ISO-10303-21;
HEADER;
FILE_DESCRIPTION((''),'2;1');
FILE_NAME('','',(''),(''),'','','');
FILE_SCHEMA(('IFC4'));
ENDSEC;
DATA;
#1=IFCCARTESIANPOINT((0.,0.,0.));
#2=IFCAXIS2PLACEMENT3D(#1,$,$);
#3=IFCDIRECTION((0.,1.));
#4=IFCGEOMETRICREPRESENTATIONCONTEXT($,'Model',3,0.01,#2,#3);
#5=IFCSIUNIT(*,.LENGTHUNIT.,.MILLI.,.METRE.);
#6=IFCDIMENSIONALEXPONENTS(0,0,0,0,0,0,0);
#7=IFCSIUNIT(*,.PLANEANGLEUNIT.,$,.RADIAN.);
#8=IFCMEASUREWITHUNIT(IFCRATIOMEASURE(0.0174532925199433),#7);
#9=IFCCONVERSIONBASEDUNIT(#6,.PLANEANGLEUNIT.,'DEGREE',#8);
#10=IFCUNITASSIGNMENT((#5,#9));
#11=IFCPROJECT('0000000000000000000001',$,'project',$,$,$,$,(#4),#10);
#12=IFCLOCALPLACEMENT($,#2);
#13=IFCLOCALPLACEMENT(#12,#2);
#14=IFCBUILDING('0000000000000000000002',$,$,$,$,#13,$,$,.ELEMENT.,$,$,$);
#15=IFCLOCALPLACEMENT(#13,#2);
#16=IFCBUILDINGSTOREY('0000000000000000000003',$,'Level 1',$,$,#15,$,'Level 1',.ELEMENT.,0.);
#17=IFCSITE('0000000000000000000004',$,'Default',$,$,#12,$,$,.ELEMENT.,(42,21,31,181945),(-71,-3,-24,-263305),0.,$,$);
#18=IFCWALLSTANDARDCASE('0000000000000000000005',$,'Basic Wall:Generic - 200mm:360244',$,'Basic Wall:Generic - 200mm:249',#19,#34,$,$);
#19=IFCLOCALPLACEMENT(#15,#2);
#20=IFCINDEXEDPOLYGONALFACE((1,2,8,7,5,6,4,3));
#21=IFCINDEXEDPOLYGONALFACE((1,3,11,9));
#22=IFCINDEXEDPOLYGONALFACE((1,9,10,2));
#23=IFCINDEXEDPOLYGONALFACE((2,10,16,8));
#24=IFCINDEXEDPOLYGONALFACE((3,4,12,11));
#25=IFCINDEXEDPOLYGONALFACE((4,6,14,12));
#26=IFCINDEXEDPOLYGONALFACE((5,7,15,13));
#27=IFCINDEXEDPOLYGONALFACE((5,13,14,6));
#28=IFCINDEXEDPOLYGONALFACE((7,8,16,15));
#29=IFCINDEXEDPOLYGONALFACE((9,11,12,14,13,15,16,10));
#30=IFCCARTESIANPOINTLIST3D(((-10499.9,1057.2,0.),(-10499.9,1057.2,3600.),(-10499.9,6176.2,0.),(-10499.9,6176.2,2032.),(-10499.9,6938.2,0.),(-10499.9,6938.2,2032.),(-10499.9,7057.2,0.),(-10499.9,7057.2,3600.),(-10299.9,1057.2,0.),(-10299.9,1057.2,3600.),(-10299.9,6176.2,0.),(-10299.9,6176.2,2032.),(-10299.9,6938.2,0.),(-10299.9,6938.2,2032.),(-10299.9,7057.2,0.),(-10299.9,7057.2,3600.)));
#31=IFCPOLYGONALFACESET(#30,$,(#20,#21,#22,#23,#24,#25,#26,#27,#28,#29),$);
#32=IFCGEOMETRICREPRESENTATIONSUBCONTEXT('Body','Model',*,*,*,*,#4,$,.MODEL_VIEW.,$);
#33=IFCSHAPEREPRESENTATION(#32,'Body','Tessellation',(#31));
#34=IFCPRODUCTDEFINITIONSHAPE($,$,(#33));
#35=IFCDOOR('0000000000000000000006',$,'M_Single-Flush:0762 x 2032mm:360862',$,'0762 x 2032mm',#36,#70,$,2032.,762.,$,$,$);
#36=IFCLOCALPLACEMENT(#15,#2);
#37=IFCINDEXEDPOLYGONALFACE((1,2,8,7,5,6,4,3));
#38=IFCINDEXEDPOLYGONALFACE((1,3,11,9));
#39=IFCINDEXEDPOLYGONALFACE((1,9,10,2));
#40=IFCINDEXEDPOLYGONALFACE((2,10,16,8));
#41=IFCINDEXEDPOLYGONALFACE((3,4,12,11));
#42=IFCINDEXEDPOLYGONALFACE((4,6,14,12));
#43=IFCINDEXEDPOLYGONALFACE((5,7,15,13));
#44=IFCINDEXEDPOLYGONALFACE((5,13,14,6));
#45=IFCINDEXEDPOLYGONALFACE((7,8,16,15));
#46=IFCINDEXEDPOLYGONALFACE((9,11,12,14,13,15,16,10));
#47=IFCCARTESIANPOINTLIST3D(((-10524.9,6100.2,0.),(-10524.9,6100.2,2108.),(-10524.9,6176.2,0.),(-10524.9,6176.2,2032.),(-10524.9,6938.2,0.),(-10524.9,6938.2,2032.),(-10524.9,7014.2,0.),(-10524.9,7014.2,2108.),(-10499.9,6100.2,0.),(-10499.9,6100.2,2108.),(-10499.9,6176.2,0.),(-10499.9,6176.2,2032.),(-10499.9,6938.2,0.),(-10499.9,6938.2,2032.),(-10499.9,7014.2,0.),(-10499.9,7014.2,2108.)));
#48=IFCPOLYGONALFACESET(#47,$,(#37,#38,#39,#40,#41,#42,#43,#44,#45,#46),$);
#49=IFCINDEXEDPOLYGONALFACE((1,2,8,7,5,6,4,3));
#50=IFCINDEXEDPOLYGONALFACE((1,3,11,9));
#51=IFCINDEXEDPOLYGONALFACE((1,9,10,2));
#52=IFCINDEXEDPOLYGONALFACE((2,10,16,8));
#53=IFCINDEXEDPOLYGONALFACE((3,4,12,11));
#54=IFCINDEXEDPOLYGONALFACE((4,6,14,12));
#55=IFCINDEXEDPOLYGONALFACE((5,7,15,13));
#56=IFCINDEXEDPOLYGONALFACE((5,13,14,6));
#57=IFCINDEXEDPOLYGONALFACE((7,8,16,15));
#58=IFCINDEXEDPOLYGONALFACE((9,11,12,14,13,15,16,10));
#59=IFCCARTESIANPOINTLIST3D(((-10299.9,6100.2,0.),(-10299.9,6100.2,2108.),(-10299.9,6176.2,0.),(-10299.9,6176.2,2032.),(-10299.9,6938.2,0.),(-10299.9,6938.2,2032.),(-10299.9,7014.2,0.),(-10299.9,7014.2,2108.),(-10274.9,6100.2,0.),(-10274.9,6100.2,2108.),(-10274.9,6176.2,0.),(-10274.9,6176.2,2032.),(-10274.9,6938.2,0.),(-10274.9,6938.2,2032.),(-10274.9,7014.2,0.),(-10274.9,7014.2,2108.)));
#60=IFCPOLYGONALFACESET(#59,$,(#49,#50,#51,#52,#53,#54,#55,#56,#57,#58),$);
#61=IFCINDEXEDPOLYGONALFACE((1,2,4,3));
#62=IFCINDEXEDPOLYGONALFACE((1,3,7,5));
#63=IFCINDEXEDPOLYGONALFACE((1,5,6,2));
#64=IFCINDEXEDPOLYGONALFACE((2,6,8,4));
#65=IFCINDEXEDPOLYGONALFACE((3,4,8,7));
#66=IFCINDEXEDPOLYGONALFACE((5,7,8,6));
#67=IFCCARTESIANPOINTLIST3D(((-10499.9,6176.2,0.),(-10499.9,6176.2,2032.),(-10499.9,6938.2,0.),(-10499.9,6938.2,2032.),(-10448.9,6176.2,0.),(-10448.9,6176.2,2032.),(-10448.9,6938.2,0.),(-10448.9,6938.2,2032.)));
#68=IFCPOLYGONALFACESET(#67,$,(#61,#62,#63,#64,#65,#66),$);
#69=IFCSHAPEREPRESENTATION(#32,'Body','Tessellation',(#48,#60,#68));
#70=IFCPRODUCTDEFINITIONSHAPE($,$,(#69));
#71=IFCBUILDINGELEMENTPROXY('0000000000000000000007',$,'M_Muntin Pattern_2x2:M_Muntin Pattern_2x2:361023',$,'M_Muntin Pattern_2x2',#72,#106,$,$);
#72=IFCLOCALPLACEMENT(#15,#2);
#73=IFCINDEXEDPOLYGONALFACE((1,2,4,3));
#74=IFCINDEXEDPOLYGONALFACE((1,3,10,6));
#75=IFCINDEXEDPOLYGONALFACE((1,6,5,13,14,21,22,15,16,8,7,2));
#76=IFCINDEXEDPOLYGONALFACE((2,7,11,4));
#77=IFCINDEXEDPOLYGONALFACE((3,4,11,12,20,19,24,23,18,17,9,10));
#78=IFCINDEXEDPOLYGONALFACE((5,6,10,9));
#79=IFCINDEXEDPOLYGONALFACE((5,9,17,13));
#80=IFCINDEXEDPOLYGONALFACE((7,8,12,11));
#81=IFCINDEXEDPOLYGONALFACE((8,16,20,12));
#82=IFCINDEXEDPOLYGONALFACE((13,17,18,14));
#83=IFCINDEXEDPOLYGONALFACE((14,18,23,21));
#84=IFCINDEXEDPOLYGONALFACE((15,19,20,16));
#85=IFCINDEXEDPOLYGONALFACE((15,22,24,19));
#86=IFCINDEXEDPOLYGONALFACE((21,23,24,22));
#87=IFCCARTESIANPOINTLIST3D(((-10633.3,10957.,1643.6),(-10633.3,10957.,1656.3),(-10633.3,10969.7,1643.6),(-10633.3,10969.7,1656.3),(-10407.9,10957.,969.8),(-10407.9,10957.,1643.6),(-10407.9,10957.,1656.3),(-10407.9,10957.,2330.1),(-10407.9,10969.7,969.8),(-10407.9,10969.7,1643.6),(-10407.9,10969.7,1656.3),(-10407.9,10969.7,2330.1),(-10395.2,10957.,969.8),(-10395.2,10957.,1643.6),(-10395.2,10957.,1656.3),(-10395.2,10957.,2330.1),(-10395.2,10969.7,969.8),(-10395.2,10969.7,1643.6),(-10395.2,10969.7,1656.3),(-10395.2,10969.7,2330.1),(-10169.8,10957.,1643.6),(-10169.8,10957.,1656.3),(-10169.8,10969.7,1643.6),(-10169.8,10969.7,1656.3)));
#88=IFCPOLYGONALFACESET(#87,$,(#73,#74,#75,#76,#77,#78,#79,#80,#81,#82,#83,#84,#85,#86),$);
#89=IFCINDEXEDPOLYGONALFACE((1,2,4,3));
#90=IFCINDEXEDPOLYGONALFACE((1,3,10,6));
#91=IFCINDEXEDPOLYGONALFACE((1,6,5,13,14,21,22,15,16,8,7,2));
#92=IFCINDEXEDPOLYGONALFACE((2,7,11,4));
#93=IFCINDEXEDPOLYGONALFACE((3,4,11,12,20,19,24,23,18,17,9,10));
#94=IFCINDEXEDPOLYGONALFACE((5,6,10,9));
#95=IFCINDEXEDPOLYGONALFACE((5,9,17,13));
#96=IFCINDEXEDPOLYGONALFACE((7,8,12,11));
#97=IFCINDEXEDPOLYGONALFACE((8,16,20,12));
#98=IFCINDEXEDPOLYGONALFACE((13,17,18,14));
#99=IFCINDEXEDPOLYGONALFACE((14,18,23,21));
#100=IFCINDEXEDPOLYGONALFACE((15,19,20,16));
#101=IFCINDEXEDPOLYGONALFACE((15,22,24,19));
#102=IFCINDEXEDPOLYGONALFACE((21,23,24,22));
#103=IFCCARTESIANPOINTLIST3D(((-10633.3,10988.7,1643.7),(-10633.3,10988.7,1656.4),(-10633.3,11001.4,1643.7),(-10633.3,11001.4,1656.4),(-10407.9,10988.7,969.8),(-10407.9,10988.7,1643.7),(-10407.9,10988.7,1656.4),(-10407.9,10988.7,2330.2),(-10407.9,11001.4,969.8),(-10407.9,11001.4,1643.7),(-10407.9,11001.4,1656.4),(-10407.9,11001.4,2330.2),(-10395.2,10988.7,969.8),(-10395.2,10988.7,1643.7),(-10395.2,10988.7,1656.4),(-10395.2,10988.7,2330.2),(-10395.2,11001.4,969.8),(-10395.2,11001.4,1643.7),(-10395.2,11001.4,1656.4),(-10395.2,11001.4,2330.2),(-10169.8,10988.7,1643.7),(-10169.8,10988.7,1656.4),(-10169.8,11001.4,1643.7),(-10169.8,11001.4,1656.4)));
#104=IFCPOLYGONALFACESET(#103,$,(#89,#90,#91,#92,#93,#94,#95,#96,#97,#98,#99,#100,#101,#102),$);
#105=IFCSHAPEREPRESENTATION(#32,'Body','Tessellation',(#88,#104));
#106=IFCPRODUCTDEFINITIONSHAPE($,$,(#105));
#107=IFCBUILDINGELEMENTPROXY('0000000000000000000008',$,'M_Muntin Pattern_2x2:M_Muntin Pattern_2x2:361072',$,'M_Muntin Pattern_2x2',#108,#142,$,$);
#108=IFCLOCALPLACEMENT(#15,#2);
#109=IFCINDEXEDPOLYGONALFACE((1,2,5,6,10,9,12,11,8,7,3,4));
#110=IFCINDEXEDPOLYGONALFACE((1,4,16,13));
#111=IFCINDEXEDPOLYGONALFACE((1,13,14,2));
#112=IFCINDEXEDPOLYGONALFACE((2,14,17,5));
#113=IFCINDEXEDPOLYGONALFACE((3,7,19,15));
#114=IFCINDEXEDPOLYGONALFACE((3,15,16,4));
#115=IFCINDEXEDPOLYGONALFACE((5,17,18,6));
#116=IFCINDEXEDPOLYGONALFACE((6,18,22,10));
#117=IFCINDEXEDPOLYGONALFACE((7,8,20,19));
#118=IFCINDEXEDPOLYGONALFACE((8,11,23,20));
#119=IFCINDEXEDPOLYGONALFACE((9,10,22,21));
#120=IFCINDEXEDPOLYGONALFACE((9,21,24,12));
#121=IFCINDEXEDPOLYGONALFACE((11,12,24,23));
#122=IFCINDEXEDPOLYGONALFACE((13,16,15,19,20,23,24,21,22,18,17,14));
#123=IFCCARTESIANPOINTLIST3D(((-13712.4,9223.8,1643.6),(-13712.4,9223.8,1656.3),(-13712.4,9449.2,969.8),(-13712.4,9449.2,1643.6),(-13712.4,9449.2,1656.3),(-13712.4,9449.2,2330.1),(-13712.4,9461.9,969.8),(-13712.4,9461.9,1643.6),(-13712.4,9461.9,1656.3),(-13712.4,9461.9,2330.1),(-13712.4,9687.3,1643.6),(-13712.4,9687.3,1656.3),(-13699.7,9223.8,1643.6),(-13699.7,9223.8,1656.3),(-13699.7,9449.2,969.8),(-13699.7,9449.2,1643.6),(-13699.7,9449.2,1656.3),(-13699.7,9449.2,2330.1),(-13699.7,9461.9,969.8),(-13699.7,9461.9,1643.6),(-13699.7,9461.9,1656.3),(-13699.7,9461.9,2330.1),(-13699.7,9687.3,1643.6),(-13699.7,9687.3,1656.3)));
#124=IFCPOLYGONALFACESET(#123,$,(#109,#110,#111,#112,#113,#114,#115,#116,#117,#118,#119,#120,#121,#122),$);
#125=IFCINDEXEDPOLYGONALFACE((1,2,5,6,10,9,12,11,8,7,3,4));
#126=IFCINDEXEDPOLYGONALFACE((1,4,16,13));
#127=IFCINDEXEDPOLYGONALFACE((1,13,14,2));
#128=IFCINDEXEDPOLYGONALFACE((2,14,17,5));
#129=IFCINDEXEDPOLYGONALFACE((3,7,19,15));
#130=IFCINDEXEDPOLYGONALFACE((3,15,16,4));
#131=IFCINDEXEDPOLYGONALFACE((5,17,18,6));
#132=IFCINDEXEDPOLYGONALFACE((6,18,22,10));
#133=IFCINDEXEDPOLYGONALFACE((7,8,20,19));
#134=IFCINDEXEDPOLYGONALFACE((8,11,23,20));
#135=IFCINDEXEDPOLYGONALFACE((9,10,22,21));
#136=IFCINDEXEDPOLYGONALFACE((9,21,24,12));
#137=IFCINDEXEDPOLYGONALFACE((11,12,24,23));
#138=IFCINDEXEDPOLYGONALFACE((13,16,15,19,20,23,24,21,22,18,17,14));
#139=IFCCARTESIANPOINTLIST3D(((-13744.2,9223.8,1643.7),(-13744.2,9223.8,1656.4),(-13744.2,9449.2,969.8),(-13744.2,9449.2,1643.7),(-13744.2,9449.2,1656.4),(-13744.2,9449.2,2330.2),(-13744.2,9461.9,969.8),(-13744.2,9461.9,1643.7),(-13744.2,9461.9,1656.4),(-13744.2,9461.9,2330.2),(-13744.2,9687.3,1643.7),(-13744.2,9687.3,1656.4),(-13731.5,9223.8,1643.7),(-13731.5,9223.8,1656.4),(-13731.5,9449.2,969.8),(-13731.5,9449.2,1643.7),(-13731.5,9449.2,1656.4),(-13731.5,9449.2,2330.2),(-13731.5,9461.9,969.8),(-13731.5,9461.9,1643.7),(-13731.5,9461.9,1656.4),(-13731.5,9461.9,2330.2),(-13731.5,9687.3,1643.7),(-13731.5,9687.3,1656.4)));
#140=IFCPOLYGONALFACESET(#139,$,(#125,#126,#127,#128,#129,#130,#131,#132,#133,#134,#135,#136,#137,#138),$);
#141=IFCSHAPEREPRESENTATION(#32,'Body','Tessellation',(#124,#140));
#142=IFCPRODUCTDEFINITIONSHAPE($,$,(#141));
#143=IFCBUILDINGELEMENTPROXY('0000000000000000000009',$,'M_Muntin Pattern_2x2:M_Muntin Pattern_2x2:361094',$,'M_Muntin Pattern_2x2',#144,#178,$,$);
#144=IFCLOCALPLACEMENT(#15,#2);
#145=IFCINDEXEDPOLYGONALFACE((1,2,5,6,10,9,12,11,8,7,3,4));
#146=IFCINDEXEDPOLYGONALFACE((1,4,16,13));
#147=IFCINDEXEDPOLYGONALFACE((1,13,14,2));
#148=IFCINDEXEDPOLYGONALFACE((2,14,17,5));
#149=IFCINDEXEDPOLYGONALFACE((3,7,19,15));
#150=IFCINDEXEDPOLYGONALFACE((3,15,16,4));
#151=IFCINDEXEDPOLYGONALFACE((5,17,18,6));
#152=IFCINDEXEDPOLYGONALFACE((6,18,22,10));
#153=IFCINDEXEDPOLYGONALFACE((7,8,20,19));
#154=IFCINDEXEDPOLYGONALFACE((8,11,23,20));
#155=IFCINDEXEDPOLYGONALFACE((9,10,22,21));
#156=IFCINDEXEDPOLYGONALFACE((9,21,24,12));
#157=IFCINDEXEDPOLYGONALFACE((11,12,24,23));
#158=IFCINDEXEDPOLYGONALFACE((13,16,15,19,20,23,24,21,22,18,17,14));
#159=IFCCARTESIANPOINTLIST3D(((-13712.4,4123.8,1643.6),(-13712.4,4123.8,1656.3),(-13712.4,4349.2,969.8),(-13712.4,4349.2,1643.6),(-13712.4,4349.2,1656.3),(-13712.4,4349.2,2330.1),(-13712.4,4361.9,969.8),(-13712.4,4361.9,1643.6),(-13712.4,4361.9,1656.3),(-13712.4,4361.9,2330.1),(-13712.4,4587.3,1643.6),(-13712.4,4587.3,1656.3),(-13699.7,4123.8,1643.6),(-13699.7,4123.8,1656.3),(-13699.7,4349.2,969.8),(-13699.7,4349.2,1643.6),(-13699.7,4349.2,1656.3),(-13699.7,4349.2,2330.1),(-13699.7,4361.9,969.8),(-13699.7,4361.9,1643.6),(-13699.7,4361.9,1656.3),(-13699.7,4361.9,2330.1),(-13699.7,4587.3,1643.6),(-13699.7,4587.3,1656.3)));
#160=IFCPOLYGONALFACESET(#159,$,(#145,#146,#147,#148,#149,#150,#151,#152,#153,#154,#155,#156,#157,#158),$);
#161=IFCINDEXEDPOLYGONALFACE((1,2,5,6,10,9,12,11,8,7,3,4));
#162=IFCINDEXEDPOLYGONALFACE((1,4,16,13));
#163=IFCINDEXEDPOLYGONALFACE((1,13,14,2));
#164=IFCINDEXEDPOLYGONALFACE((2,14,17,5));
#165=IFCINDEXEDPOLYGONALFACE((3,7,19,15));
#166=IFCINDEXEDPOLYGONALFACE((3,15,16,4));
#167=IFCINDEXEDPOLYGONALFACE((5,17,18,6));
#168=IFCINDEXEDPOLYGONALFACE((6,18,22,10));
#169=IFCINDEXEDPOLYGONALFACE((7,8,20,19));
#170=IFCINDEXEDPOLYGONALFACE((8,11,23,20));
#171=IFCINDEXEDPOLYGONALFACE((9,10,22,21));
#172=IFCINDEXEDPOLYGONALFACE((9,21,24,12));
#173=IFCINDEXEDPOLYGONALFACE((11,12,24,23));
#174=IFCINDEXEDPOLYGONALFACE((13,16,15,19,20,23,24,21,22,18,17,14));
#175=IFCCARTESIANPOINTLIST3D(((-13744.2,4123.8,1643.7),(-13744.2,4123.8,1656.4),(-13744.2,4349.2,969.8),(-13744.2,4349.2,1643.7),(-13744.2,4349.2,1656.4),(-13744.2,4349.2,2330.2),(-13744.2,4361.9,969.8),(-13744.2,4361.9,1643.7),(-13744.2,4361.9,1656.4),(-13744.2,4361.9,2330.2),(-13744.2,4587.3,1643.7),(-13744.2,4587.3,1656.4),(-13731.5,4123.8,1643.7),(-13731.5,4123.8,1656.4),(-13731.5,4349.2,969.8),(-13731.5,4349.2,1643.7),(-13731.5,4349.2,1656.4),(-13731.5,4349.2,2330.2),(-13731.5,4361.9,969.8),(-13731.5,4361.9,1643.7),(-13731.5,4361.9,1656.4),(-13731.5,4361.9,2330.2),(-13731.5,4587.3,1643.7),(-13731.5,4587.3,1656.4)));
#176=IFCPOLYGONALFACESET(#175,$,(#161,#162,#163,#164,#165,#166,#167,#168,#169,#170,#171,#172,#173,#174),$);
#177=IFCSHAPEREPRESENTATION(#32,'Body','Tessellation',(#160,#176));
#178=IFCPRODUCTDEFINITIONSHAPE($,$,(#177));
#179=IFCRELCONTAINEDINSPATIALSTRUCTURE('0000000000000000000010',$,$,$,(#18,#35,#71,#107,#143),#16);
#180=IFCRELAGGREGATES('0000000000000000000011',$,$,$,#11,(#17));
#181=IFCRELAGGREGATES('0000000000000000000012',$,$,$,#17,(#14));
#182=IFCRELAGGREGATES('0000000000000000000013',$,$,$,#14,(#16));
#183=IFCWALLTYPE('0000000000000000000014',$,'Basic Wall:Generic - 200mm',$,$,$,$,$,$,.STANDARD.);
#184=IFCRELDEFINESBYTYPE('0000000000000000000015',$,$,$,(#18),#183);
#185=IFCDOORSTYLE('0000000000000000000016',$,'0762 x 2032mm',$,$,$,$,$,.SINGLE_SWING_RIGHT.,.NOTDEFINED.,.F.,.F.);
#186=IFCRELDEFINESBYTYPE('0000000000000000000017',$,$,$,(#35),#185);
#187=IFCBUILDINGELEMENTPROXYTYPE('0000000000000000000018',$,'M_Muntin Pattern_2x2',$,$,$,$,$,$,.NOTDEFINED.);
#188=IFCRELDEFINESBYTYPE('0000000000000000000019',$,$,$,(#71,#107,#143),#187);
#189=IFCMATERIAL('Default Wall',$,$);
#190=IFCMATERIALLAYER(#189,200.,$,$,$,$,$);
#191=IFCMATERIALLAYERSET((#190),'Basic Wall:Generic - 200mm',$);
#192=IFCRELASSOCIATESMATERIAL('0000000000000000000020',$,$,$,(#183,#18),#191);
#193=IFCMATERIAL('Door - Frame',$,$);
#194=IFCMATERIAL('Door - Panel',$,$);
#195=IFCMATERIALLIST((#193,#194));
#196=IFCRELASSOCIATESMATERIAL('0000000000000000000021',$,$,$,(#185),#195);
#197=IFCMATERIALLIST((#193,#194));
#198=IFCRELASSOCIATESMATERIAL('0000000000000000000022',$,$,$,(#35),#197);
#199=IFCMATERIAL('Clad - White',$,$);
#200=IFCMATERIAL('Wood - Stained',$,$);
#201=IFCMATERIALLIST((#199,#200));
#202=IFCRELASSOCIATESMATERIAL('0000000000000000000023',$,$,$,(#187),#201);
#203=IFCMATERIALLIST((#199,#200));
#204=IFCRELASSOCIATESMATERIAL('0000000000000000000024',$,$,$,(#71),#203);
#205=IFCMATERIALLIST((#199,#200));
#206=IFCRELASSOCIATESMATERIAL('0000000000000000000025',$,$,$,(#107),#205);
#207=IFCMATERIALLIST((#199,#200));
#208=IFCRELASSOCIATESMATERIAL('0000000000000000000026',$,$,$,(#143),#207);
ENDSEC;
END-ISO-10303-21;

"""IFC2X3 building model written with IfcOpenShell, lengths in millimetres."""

from ifc_helpers import new_model, entity, si_unit, converted_unit, direction, frame, frame_2d, origin, place, context, subcontext, project, spatial, polyline, rectangle, outline, extrude, clip, bounded_halfspace, source, transform, mapped, material, material_list, layer, layer_set, layer_usage, type_object, type_shapes, element, fill, save


model = new_model("IFC2X3")

# Units and contexts
model_context = context("Model", 3, precision=0.01, world=origin(), true_north=direction((0.0, 1.0)))
body_context = subcontext(model_context, "Body", "Model", "MODEL_VIEW")
ifc_project = project(units=[si_unit("LENGTHUNIT", "METRE", prefix="MILLI"), converted_unit("PLANEANGLEUNIT", "DEGREE", entity("IfcRatioMeasure", 0.0174532925199433), si_unit("PLANEANGLEUNIT", "RADIAN"), dimensions=[0, 0, 0, 0, 0, 0, 0])], contexts=[model_context])

# Site, building, storey
site_placement = place(None, origin())
site = spatial("IfcSite", under=ifc_project, at=site_placement, Name="Default", CompositionType="ELEMENT", RefLatitude=(42, 21, 31, 181945), RefLongitude=(-71, -3, -24, -263305), RefElevation=0.0)
building_placement = place(site_placement, origin())
building = spatial("IfcBuilding", under=site, at=building_placement, CompositionType="ELEMENT")
storey_placement = place(building_placement, origin())
storey = spatial("IfcBuildingStorey", under=building, at=storey_placement, Name="Level 1", LongName="Level 1", CompositionType="ELEMENT", Elevation=0.0)

# Shared definitions
ifc_material_1 = material(Name="Default Wall")

# Shared definitions
ifc_layer_1 = layer(ifc_material_1, 200.0)
ifc_layer_set_1 = layer_set([ifc_layer_1], Name="Basic Wall:Generic - 200mm")
wall_type_1 = type_object("IfcWallType", Name="Basic Wall:Generic - 200mm", PredefinedType="STANDARD", material=ifc_layer_set_1)
ifc_material_2 = material(Name="Door - Frame")
ifc_material_3 = material(Name="Door - Panel")
ifc_material_list_1 = material_list([ifc_material_2, ifc_material_3])
door_style_1 = type_object("IfcDoorStyle", Name="0762 x 2032mm", ConstructionType="NOTDEFINED", OperationType="SINGLE_SWING_RIGHT", ParameterTakesPrecedence=False, Sizeable=False, material=ifc_material_list_1)
shared_shape_1 = source(origin(), body_context, "Body", "SweptSolid", [
    extrude(outline(polyline([(-457.0, -1073.0), (457.0, -1073.0), (457.0, 1035.0), (381.0, 1035.0), (381.0, -997.0), (-381.0, -997.0), (-381.0, 1035.0), (-457.0, 1035.0), (-457.0, -1073.0)])), frame((381.0, 200.0, 1035.0), z_axis=(0.0, 1.0, 0.0), x_axis=(1.0, 0.0, 0.0)), (0.0, 0.0, 1.0), 25.0),
    extrude(outline(polyline([(-1073.0, -457.0), (1035.0, -457.0), (1035.0, -381.0), (-997.0, -381.0), (-997.0, 381.0), (1035.0, 381.0), (1035.0, 457.0), (-1073.0, 457.0), (-1073.0, -457.0)])), frame((381.0, -25.0, 1035.0), z_axis=(0.0, 1.0, 0.0), x_axis=(0.0, 0.0, -1.0)), (0.0, 0.0, 1.0), 25.0),
    extrude(rectangle(XDim=51.0, YDim=762.0, at=frame_2d((0.0, 0.0), x_axis=(1.0, 0.0))), frame((381.0, 174.5, 0.0), z_axis=(0.0, 0.0, 1.0), x_axis=(0.0, 1.0, 0.0)), (0.0, 0.0, 1.0), 2032.0),
])
type_shapes(door_style_1, [shared_shape_1])

# Wall, opening, door
ifc_layer_usage_1 = layer_usage(ifc_layer_set_1, "AXIS2", "NEGATIVE", 100.0)
wall_1_placement = place(storey_placement, frame((-10399.9, 7057.2, 0.0), z_axis=(0.0, 0.0, 1.0), x_axis=(0.0, -1.0, 0.0)))
wall_1 = element("IfcWallStandardCase", 1, at=wall_1_placement, inside=storey, type_object=wall_type_1, material=ifc_layer_usage_1, Name="Basic Wall:Generic - 200mm:360244", ObjectType="Basic Wall:Generic - 200mm:249", context=body_context, shape_type="Clipping", body=[
    clip(extrude(rectangle(XDim=6000.0, YDim=200.0, at=frame_2d((3000.0, 0.0), x_axis=(-1.0, 0.0))), origin(), (0.0, 0.0, 1.0), 3600.0), bounded_halfspace(frame((0.0, -100.0, 3600.0), z_axis=(0.0, 0.0, -1.0), x_axis=(0.0, 1.0, 0.0)), True, frame((0.0, -100.0, 3600.0)), polyline([(0.0, 0.0), (6000.0, 0.0), (6000.0, 200.0), (0.0, 200.0), (0.0, 0.0)]))),
])
opening_1_placement = place(wall_1_placement, frame((881.0, 100.0, 0.0)))
opening_1 = element("IfcOpeningElement", 2, at=opening_1_placement, cuts=wall_1, ObjectType="Opening", context=body_context, shape_type="SweptSolid", body=[
    extrude(rectangle(XDim=762.0, YDim=2032.0, at=frame_2d((1016.0, 381.0), x_axis=(0.0, 1.0))), frame((0.0, 0.0, 0.0), z_axis=(0.0, -1.0, 0.0), x_axis=(0.0, 0.0, 1.0)), (0.0, 0.0, 1.0), 200.0),
])
ifc_material_list_2 = material_list([ifc_material_2, ifc_material_3])
door_1_placement = place(opening_1_placement, frame((0.0, 0.0, 0.0), z_axis=(0.0, 0.0, 1.0), x_axis=(-1.0, 0.0, 0.0)))
door_1 = element("IfcDoor", 3, at=door_1_placement, inside=storey, type_object=door_style_1, material=ifc_material_list_2, Name="M_Single-Flush:0762 x 2032mm:360862", ObjectType="0762 x 2032mm", OverallHeight=2032.0, OverallWidth=762.0, context=body_context, shape_type="MappedRepresentation", body=[
    mapped(shared_shape_1, transform((0.0, 0.0, 0.0), scale=1.0)),
])
fill(opening_1, door_1)

# Building element proxies
ifc_material_4 = material(Name="Clad - White")
ifc_material_5 = material(Name="Wood - Stained")
ifc_material_list_3 = material_list([ifc_material_4, ifc_material_5])
ifc_material_list_4 = material_list([ifc_material_4, ifc_material_5])
building_element_proxy_type_1 = type_object("IfcBuildingElementProxyType", Name="M_Muntin Pattern_2x2", PredefinedType="NOTDEFINED", material=ifc_material_list_4)
shared_shape_2 = source(origin(), body_context, "Body", "SweptSolid", [
    extrude(outline(polyline([(6.4, -6.4), (680.1, -6.4), (680.1, 6.3), (6.4, 6.3), (6.4, 231.7), (-6.3, 231.7), (-6.3, 6.3), (-680.2, 6.3), (-680.2, -6.4), (-6.3, -6.4), (-6.3, -231.7), (6.4, -231.7), (6.4, -6.4)])), frame((0.0, 9.5, 680.1), z_axis=(0.0, 1.0, 0.0), x_axis=(0.0, 0.0, 1.0)), (0.0, 0.0, 1.0), 12.7),
    extrude(outline(polyline([(6.4, -6.4), (680.2, -6.4), (680.2, 6.3), (6.4, 6.3), (6.4, 231.7), (-6.3, 231.7), (-6.3, 6.3), (-680.2, 6.3), (-680.2, -6.4), (-6.3, -6.4), (-6.3, -231.7), (6.4, -231.7), (6.4, -6.4)])), frame((0.0, -22.2, 680.2), z_axis=(0.0, 1.0, 0.0), x_axis=(0.0, 0.0, 1.0)), (0.0, 0.0, 1.0), 12.7),
])
type_shapes(building_element_proxy_type_1, [shared_shape_2])
proxy_1_placement = place(storey_placement, frame((-10401.5, 10979.2, 969.8), z_axis=(0.0, 0.0, 1.0), x_axis=(-1.0, 0.0, 0.0)))
element("IfcBuildingElementProxy", 4, at=proxy_1_placement, inside=storey, type_object=building_element_proxy_type_1, material=ifc_material_list_3, Name="M_Muntin Pattern_2x2:M_Muntin Pattern_2x2:361023", ObjectType="M_Muntin Pattern_2x2", context=body_context, shape_type="MappedRepresentation", body=[
    mapped(shared_shape_2, transform((0.0, 0.0, 0.0), scale=1.0)),
])
ifc_material_list_5 = material_list([ifc_material_4, ifc_material_5])
proxy_2_placement = place(storey_placement, frame((-13722.0, 9455.6, 969.8), z_axis=(0.0, 0.0, 1.0), x_axis=(0.0, -1.0, 0.0)))
element("IfcBuildingElementProxy", 5, at=proxy_2_placement, inside=storey, type_object=building_element_proxy_type_1, material=ifc_material_list_5, Name="M_Muntin Pattern_2x2:M_Muntin Pattern_2x2:361072", ObjectType="M_Muntin Pattern_2x2", context=body_context, shape_type="MappedRepresentation", body=[
    mapped(shared_shape_2, transform((0.0, 0.0, 0.0), scale=1.0)),
])
ifc_material_list_6 = material_list([ifc_material_4, ifc_material_5])
proxy_3_placement = place(storey_placement, frame((-13722.0, 4355.6, 969.8), z_axis=(0.0, 0.0, 1.0), x_axis=(0.0, -1.0, 0.0)))
element("IfcBuildingElementProxy", 6, at=proxy_3_placement, inside=storey, type_object=building_element_proxy_type_1, material=ifc_material_list_6, Name="M_Muntin Pattern_2x2:M_Muntin Pattern_2x2:361094", ObjectType="M_Muntin Pattern_2x2", context=body_context, shape_type="MappedRepresentation", body=[
    mapped(shared_shape_2, transform((0.0, 0.0, 0.0), scale=1.0)),
])

save(model, "model.ifc")
